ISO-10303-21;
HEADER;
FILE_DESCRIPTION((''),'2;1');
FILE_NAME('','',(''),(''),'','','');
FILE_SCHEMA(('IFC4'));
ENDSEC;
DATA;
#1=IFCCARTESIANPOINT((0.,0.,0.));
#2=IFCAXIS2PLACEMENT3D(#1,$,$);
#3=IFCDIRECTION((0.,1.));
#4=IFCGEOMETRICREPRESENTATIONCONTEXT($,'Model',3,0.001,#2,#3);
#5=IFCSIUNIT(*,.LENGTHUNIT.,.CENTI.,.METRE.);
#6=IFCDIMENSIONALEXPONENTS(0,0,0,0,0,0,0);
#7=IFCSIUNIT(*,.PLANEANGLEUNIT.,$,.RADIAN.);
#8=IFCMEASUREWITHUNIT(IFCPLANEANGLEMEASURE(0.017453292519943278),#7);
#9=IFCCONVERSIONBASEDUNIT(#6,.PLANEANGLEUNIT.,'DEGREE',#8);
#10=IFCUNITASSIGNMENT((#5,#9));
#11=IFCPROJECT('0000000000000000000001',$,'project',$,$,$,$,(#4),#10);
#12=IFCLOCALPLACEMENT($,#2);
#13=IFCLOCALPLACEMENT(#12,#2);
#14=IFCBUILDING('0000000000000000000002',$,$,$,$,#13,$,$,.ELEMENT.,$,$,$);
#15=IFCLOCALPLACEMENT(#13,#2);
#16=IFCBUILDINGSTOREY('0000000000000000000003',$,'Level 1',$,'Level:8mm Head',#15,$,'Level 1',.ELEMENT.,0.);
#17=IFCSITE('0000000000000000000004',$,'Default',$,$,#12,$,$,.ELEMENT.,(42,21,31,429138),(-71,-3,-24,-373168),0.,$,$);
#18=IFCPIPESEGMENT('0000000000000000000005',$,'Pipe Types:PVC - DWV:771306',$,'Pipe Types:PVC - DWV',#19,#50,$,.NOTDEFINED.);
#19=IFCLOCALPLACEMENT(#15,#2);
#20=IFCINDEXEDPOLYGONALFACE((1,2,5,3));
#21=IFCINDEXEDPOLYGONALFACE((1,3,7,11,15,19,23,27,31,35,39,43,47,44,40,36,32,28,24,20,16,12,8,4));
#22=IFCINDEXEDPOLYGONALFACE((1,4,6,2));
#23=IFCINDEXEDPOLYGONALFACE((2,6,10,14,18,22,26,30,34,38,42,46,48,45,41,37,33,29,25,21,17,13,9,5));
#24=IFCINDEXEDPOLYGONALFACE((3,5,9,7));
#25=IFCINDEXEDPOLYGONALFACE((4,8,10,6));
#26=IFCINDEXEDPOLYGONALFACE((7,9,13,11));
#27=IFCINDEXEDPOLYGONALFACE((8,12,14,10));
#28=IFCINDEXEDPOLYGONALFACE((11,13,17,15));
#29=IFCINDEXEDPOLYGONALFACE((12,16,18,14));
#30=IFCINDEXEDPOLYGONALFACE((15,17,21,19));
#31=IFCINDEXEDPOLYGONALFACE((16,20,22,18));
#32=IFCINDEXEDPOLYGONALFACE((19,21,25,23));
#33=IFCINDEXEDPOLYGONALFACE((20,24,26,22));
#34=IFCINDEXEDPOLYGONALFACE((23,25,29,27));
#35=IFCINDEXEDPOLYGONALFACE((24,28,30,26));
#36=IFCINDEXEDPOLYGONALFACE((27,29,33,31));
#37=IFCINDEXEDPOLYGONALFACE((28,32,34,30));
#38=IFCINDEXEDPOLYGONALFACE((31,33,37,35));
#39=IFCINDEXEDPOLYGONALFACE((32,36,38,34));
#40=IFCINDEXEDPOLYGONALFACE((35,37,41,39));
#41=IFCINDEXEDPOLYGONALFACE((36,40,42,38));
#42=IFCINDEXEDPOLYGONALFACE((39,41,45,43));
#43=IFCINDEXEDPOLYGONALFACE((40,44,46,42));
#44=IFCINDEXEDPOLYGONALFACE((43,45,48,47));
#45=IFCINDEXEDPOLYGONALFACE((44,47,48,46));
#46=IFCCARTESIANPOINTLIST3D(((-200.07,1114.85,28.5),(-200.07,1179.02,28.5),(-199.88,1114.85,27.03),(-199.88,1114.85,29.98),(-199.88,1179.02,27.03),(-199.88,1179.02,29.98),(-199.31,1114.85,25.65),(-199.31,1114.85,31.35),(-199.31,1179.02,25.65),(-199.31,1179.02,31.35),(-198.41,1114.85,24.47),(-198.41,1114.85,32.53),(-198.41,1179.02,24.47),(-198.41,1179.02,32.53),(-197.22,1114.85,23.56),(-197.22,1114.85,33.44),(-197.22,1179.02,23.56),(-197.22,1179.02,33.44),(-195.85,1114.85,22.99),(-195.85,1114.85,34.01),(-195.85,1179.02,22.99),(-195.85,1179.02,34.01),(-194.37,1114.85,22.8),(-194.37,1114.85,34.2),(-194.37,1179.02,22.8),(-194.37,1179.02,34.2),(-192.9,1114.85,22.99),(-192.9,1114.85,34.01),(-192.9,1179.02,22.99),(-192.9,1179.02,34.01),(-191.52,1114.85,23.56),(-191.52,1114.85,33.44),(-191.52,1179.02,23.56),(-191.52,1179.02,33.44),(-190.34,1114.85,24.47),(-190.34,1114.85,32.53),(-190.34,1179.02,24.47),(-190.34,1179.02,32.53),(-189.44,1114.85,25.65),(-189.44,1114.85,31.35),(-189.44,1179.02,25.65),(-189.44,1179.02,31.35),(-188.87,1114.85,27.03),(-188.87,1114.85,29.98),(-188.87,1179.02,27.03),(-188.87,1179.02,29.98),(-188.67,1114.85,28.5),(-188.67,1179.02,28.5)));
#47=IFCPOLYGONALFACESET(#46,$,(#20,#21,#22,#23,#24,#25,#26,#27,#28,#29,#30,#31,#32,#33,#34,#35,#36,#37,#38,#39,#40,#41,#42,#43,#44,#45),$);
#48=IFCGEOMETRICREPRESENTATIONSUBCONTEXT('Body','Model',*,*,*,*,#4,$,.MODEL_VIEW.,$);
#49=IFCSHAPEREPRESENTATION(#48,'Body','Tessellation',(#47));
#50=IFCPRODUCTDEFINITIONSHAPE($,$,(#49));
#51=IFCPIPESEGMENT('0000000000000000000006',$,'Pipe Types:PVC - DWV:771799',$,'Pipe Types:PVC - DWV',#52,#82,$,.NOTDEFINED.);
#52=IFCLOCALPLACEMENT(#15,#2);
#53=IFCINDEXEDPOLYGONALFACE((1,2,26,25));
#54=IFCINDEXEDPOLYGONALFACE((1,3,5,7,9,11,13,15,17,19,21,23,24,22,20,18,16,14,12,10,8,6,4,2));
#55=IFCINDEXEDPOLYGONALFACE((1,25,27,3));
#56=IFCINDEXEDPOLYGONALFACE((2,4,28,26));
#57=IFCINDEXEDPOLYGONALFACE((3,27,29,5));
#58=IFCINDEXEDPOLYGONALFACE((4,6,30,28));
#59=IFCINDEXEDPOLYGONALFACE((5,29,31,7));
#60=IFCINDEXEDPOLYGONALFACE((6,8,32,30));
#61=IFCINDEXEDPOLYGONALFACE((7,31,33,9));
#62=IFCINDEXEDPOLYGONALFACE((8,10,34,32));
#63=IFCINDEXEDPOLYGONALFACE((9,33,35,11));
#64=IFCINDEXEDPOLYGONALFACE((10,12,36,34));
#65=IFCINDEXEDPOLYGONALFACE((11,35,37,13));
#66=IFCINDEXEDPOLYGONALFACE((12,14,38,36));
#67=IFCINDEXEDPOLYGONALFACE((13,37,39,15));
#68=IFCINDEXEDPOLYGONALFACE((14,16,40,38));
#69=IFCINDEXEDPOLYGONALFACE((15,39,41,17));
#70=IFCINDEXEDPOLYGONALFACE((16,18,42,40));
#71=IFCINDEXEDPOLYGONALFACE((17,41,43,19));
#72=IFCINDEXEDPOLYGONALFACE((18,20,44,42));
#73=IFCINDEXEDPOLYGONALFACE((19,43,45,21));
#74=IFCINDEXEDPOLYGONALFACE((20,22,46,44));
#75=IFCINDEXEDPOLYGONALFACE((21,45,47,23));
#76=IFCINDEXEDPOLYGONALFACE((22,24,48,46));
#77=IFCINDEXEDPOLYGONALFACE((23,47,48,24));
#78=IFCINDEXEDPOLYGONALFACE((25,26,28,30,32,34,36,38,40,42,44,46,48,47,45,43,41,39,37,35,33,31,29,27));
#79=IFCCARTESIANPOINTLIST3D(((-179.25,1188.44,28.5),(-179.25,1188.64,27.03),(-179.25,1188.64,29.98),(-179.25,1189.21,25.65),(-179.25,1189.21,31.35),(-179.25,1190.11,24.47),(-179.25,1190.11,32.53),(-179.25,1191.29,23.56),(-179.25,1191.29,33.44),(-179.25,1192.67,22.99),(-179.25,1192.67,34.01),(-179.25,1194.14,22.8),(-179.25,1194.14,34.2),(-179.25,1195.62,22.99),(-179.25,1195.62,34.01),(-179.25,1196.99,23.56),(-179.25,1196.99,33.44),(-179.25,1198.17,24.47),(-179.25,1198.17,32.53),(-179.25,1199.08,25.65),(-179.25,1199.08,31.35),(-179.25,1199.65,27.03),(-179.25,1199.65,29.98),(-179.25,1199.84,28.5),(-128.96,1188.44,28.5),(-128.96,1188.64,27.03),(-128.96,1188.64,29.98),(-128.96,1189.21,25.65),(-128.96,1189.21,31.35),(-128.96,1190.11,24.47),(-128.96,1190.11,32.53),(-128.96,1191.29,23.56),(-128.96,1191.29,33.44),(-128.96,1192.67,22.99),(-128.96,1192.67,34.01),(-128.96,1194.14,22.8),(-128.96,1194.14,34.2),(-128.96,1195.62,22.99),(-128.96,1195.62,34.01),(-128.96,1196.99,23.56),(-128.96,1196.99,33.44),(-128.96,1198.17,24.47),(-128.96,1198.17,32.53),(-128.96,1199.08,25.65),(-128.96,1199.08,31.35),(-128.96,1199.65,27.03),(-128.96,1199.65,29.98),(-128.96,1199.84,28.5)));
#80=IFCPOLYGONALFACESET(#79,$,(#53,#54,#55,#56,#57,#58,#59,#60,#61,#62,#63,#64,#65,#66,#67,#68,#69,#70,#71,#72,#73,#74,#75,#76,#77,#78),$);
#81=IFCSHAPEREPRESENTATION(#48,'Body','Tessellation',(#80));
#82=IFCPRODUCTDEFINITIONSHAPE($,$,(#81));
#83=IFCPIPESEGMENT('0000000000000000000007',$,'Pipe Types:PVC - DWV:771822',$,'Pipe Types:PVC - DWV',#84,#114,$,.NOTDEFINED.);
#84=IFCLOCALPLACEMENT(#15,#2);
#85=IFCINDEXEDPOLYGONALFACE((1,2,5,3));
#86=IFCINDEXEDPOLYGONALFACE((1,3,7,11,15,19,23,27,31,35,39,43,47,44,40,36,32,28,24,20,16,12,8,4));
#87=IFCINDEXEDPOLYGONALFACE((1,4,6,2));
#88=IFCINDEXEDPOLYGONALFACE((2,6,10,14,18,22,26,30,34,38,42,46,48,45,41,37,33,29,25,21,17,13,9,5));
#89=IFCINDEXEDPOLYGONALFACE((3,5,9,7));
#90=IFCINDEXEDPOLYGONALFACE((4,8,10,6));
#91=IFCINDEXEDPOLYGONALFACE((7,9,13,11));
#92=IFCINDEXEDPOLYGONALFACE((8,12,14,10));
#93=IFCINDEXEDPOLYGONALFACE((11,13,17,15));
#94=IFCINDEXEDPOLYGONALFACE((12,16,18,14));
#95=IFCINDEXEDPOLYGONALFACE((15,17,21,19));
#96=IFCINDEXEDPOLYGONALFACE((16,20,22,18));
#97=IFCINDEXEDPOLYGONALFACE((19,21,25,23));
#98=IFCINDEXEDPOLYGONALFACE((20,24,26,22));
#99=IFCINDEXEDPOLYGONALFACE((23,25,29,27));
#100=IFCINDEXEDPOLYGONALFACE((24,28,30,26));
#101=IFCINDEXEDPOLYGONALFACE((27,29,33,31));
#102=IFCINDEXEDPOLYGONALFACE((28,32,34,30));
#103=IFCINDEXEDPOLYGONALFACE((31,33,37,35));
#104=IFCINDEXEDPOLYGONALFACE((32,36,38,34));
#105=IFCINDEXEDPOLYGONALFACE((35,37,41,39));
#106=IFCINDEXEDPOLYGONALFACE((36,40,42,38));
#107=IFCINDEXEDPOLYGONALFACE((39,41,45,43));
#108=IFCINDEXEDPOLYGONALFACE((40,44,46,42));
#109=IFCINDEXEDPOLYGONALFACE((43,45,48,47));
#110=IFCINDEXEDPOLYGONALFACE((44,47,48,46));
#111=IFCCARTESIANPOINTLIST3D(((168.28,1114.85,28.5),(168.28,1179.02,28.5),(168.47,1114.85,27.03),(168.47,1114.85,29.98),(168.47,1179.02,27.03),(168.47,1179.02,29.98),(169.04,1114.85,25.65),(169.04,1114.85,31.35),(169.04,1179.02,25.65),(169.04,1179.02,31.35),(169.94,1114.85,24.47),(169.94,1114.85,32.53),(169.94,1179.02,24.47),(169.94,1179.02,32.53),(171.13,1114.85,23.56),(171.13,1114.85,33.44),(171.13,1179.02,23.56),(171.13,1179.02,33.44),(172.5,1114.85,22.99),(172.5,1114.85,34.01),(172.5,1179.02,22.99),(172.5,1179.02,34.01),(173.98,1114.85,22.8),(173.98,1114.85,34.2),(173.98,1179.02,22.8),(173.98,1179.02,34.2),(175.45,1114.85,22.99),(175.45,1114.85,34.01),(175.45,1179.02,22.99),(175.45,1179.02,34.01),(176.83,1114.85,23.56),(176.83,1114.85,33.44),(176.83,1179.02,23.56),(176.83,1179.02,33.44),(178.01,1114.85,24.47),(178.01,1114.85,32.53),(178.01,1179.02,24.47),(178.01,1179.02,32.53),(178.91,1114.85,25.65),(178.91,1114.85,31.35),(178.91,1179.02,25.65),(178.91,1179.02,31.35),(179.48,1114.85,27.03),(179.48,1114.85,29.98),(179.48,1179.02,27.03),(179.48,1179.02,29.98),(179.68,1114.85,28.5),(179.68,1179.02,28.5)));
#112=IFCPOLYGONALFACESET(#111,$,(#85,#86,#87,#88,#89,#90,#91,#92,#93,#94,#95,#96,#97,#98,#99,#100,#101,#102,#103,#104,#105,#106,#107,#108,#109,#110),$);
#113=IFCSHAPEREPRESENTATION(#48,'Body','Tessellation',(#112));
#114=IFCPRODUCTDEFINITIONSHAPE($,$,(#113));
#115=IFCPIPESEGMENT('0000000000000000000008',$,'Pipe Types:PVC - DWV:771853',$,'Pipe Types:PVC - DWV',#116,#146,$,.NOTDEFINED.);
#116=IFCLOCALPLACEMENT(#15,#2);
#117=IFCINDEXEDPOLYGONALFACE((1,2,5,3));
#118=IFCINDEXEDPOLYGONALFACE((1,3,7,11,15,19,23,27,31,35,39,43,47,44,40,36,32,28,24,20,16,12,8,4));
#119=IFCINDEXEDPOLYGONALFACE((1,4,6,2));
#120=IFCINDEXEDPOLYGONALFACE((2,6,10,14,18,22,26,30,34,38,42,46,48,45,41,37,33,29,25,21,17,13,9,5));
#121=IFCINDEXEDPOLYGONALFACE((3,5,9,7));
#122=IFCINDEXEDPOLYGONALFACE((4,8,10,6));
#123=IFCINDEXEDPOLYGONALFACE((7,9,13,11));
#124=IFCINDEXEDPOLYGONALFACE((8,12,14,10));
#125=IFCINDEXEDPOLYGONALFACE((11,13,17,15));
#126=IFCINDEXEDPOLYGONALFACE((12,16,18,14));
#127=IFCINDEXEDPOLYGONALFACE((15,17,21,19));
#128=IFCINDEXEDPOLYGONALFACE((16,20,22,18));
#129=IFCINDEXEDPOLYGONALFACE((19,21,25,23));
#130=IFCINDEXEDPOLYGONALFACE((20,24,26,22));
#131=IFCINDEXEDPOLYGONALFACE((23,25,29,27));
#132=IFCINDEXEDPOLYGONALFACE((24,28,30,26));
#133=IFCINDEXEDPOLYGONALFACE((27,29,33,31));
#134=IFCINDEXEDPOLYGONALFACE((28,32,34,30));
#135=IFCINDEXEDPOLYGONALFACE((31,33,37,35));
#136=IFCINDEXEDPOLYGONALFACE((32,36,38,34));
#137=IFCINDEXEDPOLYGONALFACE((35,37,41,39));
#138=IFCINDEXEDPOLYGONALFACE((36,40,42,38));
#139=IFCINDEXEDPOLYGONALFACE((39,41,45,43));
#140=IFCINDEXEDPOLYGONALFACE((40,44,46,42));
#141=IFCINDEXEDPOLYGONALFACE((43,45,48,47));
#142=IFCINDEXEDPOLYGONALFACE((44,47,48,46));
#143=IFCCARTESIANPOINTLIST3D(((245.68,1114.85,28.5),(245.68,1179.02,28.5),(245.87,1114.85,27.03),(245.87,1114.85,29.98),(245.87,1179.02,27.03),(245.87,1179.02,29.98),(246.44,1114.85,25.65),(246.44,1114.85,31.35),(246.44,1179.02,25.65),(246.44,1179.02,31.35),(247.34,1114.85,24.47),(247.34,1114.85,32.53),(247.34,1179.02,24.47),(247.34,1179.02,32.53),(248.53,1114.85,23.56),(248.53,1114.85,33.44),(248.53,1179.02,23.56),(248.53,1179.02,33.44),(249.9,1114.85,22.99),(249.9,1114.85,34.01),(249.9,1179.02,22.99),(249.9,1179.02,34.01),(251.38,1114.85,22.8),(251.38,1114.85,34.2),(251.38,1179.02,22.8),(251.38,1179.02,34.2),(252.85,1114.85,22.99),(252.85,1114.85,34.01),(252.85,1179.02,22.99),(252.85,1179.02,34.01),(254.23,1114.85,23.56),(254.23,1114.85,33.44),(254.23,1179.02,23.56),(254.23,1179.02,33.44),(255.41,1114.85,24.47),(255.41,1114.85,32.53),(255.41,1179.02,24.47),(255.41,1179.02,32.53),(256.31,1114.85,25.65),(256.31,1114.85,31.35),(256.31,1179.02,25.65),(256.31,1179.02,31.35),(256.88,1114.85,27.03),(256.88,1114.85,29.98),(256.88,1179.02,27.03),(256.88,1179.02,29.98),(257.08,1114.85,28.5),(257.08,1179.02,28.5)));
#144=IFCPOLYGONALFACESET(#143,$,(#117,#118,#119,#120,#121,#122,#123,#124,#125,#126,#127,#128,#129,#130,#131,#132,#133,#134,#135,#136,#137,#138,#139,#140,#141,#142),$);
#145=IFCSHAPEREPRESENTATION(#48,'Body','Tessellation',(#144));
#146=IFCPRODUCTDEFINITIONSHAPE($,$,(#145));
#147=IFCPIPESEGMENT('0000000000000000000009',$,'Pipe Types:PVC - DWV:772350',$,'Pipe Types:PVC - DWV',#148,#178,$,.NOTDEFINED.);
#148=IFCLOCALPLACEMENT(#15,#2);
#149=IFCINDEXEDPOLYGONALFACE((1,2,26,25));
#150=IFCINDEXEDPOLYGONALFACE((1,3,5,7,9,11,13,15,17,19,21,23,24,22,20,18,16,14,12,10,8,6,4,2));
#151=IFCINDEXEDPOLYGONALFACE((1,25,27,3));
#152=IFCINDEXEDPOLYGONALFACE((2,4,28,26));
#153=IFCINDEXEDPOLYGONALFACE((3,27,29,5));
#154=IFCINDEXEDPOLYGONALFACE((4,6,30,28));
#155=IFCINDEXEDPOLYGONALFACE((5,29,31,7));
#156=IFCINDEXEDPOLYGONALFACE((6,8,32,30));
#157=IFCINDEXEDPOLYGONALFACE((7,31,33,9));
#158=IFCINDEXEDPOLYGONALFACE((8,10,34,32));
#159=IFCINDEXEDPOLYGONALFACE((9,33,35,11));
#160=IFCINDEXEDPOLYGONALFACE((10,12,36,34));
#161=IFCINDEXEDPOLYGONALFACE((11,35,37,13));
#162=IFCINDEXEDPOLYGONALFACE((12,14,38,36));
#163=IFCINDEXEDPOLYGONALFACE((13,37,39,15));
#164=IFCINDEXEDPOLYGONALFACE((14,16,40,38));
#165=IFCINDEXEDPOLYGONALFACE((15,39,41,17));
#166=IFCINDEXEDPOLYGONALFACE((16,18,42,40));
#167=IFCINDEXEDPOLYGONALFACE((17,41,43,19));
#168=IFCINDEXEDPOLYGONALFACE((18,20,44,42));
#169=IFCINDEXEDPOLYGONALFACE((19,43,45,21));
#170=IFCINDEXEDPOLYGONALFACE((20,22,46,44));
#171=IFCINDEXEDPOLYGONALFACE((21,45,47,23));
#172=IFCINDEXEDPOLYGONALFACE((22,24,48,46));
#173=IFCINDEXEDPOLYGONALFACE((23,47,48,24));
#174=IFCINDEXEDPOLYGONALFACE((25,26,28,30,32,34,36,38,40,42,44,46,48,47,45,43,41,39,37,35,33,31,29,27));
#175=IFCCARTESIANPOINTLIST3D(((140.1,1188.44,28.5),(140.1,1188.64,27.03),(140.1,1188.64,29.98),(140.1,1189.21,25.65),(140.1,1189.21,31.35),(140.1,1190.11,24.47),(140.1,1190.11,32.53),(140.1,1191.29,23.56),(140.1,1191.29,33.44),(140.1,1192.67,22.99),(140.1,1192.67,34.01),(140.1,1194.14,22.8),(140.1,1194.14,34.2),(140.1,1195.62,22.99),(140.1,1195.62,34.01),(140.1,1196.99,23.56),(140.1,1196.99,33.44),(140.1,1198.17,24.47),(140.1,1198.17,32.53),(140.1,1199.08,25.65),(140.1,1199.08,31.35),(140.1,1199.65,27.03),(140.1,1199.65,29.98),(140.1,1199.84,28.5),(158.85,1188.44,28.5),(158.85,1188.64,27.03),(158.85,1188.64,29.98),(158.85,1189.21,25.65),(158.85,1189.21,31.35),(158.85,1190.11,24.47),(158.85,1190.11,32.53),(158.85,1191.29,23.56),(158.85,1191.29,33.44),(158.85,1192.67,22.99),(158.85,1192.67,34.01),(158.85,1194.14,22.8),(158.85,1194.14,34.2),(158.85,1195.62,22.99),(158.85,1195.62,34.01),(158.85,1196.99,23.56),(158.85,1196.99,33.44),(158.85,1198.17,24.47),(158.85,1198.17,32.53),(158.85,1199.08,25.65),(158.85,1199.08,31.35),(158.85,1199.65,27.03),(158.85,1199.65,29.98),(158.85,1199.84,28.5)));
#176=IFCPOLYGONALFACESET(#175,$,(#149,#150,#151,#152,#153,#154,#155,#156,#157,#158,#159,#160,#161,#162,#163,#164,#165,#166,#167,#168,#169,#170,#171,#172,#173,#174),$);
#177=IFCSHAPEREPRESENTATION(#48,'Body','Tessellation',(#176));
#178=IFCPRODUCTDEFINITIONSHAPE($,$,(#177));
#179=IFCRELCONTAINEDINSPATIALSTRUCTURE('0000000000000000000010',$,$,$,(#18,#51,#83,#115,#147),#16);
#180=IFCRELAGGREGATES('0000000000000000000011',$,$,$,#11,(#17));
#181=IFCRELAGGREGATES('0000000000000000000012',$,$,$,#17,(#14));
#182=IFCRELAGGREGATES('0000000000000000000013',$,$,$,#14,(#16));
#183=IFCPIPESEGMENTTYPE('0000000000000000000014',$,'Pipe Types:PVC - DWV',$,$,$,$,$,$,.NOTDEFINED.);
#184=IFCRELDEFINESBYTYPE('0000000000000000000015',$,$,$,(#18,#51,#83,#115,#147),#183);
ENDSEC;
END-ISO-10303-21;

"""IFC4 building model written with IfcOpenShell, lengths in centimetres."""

from ifc_helpers import new_model, entity, si_unit, converted_unit, direction, frame, origin, place, context, subcontext, project, spatial, arc, indexed_curve, outline, extrude, type_object, element, save


model = new_model("IFC4")

# Units and contexts
model_context = context("Model", 3, precision=0.001, world=origin(), true_north=direction((0.0, 1.0)))
body_context = subcontext(model_context, "Body", "Model", "MODEL_VIEW")
ifc_project = project(units=[si_unit("LENGTHUNIT", "METRE", prefix="CENTI"), converted_unit("PLANEANGLEUNIT", "DEGREE", entity("IfcPlaneAngleMeasure", 0.017453292519943278), si_unit("PLANEANGLEUNIT", "RADIAN"), dimensions=[0, 0, 0, 0, 0, 0, 0])], contexts=[model_context])

# Site, building, storey
site_placement = place(None, origin())
site = spatial("IfcSite", under=ifc_project, at=site_placement, Name="Default", CompositionType="ELEMENT", RefLatitude=(42, 21, 31, 429138), RefLongitude=(-71, -3, -24, -373168), RefElevation=0.0)
building_placement = place(site_placement, origin())
building = spatial("IfcBuilding", under=site, at=building_placement, CompositionType="ELEMENT")
storey_placement = place(building_placement, origin())
storey = spatial("IfcBuildingStorey", under=building, at=storey_placement, Name="Level 1", ObjectType="Level:8mm Head", LongName="Level 1", CompositionType="ELEMENT", Elevation=0.0)

# Pipe segments
pipe_segment_type = type_object("IfcPipeSegmentType", Name="Pipe Types:PVC - DWV", PredefinedType="NOTDEFINED")
pipe_segment_1_placement = place(storey_placement, origin())
element("IfcPipeSegment", 1, at=pipe_segment_1_placement, inside=storey, type_object=pipe_segment_type, Name="Pipe Types:PVC - DWV:771306", ObjectType="Pipe Types:PVC - DWV", PredefinedType="NOTDEFINED", context=body_context, shape_type="SweptSolid", body=[
    extrude(outline(indexed_curve([(5.7, 0.0), (4.03, 4.03), (0.0, 5.7), (-4.03, 4.03), (-5.7, 0.0), (-4.03, -4.03), (0.0, -5.7), (4.03, -4.03)], segments=[arc(1, 2, 3), arc(3, 4, 5), arc(5, 6, 7), arc(7, 8, 1)], self_intersect=False)), frame((-194.37, 1114.85, 28.5), z_axis=(0.0, 1.0, 0.0), x_axis=(1.0, 0.0, 0.0)), (0.0, 0.0, 1.0), 64.18),
])
pipe_segment_2_placement = place(storey_placement, origin())
element("IfcPipeSegment", 2, at=pipe_segment_2_placement, inside=storey, type_object=pipe_segment_type, Name="Pipe Types:PVC - DWV:771799", ObjectType="Pipe Types:PVC - DWV", PredefinedType="NOTDEFINED", context=body_context, shape_type="SweptSolid", body=[
    extrude(outline(indexed_curve([(5.7, 0.0), (4.03, 4.03), (0.0, 5.7), (-4.03, 4.03), (-5.7, 0.0), (-4.03, -4.03), (0.0, -5.7), (4.03, -4.03)], segments=[arc(1, 2, 3), arc(3, 4, 5), arc(5, 6, 7), arc(7, 8, 1)], self_intersect=False)), frame((-179.25, 1194.14, 28.5), z_axis=(1.0, 0.0, 0.0), x_axis=(0.0, 1.0, 0.0)), (0.0, 0.0, 1.0), 50.29),
])
pipe_segment_3_placement = place(storey_placement, origin())
element("IfcPipeSegment", 3, at=pipe_segment_3_placement, inside=storey, type_object=pipe_segment_type, Name="Pipe Types:PVC - DWV:771822", ObjectType="Pipe Types:PVC - DWV", PredefinedType="NOTDEFINED", context=body_context, shape_type="SweptSolid", body=[
    extrude(outline(indexed_curve([(5.7, 0.0), (4.03, 4.03), (0.0, 5.7), (-4.03, 4.03), (-5.7, 0.0), (-4.03, -4.03), (0.0, -5.7), (4.03, -4.03)], segments=[arc(1, 2, 3), arc(3, 4, 5), arc(5, 6, 7), arc(7, 8, 1)], self_intersect=False)), frame((173.98, 1114.85, 28.5), z_axis=(0.0, 1.0, 0.0), x_axis=(1.0, 0.0, 0.0)), (0.0, 0.0, 1.0), 64.18),
])
pipe_segment_4_placement = place(storey_placement, origin())
element("IfcPipeSegment", 4, at=pipe_segment_4_placement, inside=storey, type_object=pipe_segment_type, Name="Pipe Types:PVC - DWV:771853", ObjectType="Pipe Types:PVC - DWV", PredefinedType="NOTDEFINED", context=body_context, shape_type="SweptSolid", body=[
    extrude(outline(indexed_curve([(5.7, 0.0), (4.03, 4.03), (0.0, 5.7), (-4.03, 4.03), (-5.7, 0.0), (-4.03, -4.03), (0.0, -5.7), (4.03, -4.03)], segments=[arc(1, 2, 3), arc(3, 4, 5), arc(5, 6, 7), arc(7, 8, 1)], self_intersect=False)), frame((251.38, 1114.85, 28.5), z_axis=(0.0, 1.0, 0.0), x_axis=(1.0, 0.0, 0.0)), (0.0, 0.0, 1.0), 64.18),
])
pipe_segment_5_placement = place(storey_placement, origin())
element("IfcPipeSegment", 5, at=pipe_segment_5_placement, inside=storey, type_object=pipe_segment_type, Name="Pipe Types:PVC - DWV:772350", ObjectType="Pipe Types:PVC - DWV", PredefinedType="NOTDEFINED", context=body_context, shape_type="SweptSolid", body=[
    extrude(outline(indexed_curve([(5.7, 0.0), (4.03, 4.03), (0.0, 5.7), (-4.03, 4.03), (-5.7, 0.0), (-4.03, -4.03), (0.0, -5.7), (4.03, -4.03)], segments=[arc(1, 2, 3), arc(3, 4, 5), arc(5, 6, 7), arc(7, 8, 1)], self_intersect=False)), frame((140.1, 1194.14, 28.5), z_axis=(1.0, 0.0, 0.0), x_axis=(0.0, 1.0, 0.0)), (0.0, 0.0, 1.0), 18.76),
])

save(model, "model.ifc")
